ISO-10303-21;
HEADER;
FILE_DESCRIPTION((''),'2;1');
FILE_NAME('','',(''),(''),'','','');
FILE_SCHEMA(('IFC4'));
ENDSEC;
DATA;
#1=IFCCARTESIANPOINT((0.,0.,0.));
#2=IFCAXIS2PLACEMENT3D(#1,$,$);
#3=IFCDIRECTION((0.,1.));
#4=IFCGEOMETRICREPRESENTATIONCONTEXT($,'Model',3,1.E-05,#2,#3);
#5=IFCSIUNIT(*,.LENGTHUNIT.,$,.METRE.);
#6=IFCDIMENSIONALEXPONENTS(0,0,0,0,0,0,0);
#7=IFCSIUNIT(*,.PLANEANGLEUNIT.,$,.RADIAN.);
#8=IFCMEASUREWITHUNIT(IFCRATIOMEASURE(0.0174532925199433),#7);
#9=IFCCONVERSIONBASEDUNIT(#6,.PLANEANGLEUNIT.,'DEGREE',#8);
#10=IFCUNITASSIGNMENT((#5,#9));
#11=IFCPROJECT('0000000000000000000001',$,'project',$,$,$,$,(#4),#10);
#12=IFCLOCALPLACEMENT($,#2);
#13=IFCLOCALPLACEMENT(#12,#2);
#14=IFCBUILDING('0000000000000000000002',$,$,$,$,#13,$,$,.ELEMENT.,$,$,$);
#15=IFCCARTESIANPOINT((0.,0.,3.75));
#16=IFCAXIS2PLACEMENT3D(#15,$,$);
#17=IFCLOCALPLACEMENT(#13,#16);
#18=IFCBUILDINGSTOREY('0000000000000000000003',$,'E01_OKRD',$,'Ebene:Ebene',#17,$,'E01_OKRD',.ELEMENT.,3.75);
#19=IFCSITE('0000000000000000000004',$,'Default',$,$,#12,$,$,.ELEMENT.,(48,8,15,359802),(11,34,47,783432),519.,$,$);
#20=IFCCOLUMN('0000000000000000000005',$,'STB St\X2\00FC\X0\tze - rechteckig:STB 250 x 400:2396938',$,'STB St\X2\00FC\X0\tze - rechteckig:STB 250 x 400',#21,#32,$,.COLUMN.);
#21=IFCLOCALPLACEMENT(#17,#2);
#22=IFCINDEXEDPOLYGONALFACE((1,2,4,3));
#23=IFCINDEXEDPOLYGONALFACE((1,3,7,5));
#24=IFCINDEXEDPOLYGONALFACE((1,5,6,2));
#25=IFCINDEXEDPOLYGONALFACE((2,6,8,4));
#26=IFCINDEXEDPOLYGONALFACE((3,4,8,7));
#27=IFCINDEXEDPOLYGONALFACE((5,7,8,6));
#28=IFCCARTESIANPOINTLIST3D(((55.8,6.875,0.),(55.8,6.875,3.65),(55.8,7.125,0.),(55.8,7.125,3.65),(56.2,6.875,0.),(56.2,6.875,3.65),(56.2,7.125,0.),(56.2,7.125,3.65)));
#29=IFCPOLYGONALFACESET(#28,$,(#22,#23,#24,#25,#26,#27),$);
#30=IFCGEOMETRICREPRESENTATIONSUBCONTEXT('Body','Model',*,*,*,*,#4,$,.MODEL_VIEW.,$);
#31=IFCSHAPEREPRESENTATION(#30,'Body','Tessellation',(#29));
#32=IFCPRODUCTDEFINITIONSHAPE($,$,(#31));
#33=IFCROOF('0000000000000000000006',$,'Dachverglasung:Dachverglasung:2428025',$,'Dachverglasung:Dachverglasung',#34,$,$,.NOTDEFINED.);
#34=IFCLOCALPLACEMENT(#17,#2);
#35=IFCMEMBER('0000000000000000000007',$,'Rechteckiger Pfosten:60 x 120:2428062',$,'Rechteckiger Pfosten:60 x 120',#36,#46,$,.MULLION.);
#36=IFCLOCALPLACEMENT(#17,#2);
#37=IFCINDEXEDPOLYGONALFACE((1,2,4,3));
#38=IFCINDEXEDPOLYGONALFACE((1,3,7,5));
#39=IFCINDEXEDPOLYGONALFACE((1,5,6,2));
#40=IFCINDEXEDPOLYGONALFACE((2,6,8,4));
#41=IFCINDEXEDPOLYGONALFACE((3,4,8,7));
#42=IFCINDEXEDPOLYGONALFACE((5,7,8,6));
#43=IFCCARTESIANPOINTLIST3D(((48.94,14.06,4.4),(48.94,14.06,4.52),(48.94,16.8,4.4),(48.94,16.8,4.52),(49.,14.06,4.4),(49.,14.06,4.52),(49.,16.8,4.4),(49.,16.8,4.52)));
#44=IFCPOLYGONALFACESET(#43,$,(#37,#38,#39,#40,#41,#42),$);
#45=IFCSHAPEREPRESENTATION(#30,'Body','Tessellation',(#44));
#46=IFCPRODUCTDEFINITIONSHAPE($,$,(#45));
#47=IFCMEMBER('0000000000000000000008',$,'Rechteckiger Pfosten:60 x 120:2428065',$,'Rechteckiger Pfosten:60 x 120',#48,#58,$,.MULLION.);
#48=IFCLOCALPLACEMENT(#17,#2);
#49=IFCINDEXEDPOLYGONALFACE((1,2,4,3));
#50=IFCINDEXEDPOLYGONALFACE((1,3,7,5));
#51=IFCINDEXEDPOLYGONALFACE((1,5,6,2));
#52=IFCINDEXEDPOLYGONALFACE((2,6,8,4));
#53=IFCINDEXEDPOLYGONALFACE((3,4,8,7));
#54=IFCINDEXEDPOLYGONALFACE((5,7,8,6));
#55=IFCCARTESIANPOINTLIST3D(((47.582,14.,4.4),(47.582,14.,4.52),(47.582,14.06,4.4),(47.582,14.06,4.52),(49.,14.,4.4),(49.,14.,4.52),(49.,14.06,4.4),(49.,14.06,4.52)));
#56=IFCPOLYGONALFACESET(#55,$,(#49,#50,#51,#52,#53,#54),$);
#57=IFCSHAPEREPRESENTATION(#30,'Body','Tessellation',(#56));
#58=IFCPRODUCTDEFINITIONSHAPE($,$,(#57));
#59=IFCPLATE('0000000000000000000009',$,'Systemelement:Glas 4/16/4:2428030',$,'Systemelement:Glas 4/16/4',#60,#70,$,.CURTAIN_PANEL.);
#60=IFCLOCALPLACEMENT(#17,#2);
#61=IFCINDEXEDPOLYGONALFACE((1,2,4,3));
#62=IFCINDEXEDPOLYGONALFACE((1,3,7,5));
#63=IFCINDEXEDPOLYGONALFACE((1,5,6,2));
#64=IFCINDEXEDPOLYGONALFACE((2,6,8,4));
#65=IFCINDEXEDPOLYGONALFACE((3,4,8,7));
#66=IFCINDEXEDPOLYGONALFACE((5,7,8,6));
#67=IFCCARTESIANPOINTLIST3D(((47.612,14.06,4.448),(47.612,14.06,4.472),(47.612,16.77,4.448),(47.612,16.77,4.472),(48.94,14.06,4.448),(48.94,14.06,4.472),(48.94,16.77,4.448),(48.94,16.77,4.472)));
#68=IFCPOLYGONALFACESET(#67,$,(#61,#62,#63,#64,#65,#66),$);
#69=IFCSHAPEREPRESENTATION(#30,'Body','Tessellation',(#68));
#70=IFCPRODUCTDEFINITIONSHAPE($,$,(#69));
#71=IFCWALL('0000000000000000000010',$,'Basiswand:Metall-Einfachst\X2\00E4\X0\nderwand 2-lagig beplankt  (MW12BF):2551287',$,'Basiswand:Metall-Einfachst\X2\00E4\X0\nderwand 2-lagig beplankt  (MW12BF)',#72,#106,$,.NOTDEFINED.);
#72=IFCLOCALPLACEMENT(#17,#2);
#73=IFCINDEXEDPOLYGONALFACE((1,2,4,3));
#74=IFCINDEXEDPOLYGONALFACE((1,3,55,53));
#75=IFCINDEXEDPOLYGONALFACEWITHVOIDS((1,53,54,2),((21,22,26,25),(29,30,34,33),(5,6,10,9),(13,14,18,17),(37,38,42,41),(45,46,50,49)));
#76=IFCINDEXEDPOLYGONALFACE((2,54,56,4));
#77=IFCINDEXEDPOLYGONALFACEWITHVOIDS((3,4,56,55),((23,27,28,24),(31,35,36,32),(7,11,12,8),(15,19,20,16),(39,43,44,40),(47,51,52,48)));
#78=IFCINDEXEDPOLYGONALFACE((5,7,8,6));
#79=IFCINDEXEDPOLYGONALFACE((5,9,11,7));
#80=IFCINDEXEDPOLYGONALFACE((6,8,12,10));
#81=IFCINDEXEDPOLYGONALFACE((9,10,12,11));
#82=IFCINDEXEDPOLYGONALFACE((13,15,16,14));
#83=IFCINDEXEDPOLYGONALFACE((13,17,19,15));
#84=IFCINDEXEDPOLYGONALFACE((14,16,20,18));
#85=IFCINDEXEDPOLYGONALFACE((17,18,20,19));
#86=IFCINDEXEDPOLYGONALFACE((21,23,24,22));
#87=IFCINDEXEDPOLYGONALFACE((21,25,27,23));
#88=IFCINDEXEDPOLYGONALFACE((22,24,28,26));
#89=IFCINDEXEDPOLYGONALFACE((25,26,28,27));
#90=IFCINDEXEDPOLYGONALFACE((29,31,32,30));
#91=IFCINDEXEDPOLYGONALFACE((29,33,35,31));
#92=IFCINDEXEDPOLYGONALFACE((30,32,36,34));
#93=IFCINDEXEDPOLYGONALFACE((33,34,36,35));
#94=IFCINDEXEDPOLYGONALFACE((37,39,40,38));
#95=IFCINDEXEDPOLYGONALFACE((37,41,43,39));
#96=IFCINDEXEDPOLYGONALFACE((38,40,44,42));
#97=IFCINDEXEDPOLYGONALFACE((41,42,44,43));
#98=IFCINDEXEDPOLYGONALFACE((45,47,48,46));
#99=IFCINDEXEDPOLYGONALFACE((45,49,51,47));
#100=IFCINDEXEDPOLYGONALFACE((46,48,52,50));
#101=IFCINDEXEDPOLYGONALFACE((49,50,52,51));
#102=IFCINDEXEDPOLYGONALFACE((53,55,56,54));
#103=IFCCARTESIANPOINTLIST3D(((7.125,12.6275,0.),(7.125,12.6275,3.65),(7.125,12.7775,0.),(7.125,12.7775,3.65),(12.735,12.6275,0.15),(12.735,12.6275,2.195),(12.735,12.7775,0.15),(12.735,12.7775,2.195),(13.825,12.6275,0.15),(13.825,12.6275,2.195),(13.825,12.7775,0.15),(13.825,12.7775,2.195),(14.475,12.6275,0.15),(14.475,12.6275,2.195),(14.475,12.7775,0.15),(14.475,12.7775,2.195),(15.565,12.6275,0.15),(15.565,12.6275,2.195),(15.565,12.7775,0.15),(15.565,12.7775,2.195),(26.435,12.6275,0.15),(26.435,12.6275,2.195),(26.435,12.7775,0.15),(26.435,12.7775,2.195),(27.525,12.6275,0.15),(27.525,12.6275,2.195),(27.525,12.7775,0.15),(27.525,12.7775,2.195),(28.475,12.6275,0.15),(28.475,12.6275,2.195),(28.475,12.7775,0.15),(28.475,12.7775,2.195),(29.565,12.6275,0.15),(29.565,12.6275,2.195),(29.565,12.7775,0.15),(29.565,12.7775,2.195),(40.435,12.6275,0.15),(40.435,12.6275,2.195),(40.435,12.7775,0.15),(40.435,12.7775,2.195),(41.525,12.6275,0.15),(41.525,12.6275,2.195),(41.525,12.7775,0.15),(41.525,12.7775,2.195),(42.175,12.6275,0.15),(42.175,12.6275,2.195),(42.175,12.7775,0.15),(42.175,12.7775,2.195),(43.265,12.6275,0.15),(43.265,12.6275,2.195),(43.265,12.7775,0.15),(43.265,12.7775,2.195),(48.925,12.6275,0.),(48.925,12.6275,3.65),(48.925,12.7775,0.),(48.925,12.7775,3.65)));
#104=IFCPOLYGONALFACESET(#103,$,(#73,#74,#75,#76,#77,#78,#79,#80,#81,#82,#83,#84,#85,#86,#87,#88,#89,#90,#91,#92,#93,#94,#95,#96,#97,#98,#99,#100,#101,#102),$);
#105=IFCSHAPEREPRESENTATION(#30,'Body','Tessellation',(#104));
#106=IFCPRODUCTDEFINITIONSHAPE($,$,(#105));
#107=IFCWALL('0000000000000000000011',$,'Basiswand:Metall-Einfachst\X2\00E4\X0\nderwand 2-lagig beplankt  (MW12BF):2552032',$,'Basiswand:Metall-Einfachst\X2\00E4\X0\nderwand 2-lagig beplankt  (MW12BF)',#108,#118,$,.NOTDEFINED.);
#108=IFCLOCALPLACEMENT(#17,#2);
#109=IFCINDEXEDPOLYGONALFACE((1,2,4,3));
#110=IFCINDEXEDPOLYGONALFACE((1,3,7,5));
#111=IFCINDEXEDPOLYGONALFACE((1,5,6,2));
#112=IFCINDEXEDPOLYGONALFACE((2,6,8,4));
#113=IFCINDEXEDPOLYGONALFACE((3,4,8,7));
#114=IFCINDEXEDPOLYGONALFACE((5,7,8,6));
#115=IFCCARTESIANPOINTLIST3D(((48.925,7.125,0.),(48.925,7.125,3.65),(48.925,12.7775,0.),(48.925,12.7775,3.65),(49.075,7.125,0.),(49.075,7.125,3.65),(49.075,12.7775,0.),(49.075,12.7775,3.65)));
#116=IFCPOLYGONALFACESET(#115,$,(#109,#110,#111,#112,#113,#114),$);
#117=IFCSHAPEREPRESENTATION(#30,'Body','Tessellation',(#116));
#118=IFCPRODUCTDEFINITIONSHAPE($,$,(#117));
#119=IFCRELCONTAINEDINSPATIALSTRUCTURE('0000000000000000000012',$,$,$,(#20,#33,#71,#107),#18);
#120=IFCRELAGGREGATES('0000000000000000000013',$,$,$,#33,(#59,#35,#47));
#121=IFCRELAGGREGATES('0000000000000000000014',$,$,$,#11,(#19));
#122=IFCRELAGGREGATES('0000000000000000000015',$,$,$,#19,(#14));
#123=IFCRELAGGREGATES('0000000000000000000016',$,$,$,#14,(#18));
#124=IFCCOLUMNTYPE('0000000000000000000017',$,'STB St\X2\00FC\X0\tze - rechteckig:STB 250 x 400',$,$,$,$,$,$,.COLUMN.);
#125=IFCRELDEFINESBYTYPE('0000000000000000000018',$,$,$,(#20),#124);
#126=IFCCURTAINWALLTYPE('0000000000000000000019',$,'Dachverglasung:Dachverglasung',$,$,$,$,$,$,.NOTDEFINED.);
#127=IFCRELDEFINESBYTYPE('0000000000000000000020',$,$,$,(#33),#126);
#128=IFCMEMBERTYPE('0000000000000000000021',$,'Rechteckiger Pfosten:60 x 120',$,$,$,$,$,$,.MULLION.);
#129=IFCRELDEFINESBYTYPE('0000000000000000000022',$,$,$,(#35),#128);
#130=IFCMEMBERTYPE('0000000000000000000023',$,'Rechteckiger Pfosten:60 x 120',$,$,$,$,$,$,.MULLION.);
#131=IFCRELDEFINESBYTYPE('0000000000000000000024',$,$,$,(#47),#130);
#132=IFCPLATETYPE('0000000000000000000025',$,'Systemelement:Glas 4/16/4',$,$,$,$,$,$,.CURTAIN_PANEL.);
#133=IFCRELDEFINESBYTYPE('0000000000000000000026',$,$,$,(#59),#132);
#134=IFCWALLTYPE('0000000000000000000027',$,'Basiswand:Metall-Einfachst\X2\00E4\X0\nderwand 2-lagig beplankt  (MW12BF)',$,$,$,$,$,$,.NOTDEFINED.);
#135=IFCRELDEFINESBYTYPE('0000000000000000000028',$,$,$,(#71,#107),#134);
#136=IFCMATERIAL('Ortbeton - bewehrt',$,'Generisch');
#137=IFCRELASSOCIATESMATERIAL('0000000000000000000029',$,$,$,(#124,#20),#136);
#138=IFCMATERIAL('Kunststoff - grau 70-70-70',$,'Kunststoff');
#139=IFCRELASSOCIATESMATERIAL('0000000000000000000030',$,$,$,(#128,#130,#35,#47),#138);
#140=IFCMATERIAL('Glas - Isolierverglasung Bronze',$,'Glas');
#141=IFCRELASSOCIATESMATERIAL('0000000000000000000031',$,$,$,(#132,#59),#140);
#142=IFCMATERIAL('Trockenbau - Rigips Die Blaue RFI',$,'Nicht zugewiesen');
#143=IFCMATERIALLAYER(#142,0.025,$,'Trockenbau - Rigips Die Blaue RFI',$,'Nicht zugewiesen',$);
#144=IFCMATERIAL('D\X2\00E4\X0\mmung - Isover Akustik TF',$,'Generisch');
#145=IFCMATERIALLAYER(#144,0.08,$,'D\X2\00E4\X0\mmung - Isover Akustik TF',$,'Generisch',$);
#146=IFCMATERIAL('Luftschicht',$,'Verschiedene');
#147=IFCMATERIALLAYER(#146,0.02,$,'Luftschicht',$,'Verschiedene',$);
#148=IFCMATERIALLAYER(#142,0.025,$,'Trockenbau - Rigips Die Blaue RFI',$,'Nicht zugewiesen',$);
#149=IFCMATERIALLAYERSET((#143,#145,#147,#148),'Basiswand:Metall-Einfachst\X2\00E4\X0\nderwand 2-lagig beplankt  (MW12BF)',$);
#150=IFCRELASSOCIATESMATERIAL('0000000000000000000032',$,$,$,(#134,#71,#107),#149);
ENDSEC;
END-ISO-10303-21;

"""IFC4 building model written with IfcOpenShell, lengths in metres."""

from ifc_helpers import new_model, entity, si_unit, converted_unit, direction, frame, frame_2d, origin, origin_2d_with_axis, place, context, subcontext, project, spatial, rectangle, extrude, shape, source, transform, mapped, material, layer, layer_set, layer_usage, material_profile, profile_set, profile_usage, type_object, type_shapes, element, aggregate, save


model = new_model("IFC4")

# Units and contexts
model_context = context("Model", 3, precision=1e-05, world=origin(), true_north=direction((0.0, 1.0)))
body_context = subcontext(model_context, "Body", "Model", "MODEL_VIEW")
footprint_context = subcontext(model_context, "FootPrint", "Model", "MODEL_VIEW")
ifc_project = project(units=[si_unit("LENGTHUNIT", "METRE"), converted_unit("PLANEANGLEUNIT", "DEGREE", entity("IfcRatioMeasure", 0.0174532925199433), si_unit("PLANEANGLEUNIT", "RADIAN"), dimensions=[0, 0, 0, 0, 0, 0, 0])], contexts=[model_context])

# Site, building, storey
site_placement = place(None, frame((0.0, 0.0, 0.0)))
site = spatial("IfcSite", under=ifc_project, at=site_placement, Name="Default", CompositionType="ELEMENT", RefLatitude=(48, 8, 15, 359802), RefLongitude=(11, 34, 47, 783432), RefElevation=519.0)
building_placement = place(site_placement, origin())
building = spatial("IfcBuilding", under=site, at=building_placement, CompositionType="ELEMENT")
storey_placement = place(building_placement, frame((0.0, 0.0, 3.75)))
storey = spatial("IfcBuildingStorey", under=building, at=storey_placement, Name="E01_OKRD", ObjectType="Ebene:Ebene", LongName="E01_OKRD", CompositionType="ELEMENT", Elevation=3.75)

# Column
ifc_material_1 = material(Name="Ortbeton - bewehrt", Category="Generisch")
ifc_material_profile_1 = material_profile(ifc_material_1, rectangle(XDim=0.4, YDim=0.25, at=frame_2d((0.0, 0.0), x_axis=(1.0, 0.0))), Name="STB 250 x 400")
ifc_profile_set_1 = profile_set([ifc_material_profile_1], Name="STB 250 x 400")
ifc_profile_usage_1 = profile_usage(ifc_profile_set_1)
column_type = type_object("IfcColumnType", Name="STB Stütze - rechteckig:STB 250 x 400", PredefinedType="COLUMN", material=ifc_profile_set_1)
shared_shape_1 = source(origin(), body_context, "Body", "SweptSolid", [
    extrude(rectangle(XDim=0.4, YDim=0.25, at=frame_2d((0.0, 0.0), x_axis=(1.0, 0.0))), frame((0.2, 0.125, 0.0), z_axis=(0.0, 0.0, 1.0), x_axis=(-1.0, 0.0, 0.0)), (0.0, 0.0, 1.0), 3.65),
])
type_shapes(column_type, [shared_shape_1])
column_placement = place(storey_placement, frame((55.8, 6.875, 0.0)))
element("IfcColumn", 1, at=column_placement, inside=storey, type_object=column_type, material=ifc_profile_usage_1, Name="STB Stütze - rechteckig:STB 250 x 400:2396938", ObjectType="STB Stütze - rechteckig:STB 250 x 400", PredefinedType="COLUMN", context=body_context, shape_type="MappedRepresentation", body=[
    mapped(shared_shape_1, transform((0.0, 0.0, 0.0), scale=1.0)),
])

# Roof, members, plate
curtain_wall_type = type_object("IfcCurtainWallType", Name="Dachverglasung:Dachverglasung", PredefinedType="NOTDEFINED")
roof_placement = place(storey_placement, frame((0.0, 0.0, -3.75)))
roof = element("IfcRoof", 2, at=roof_placement, inside=storey, type_object=curtain_wall_type, Name="Dachverglasung:Dachverglasung:2428025", ObjectType="Dachverglasung:Dachverglasung", PredefinedType="NOTDEFINED")
ifc_material_2 = material(Name="Kunststoff - grau 70-70-70", Category="Kunststoff")
ifc_material_profile_2 = material_profile(ifc_material_2, rectangle(XDim=0.06, YDim=0.12, at=frame_2d((0.0, 0.0), x_axis=(1.0, 0.0))), Name="60 x 120")
ifc_profile_set_2 = profile_set([ifc_material_profile_2], Name="60 x 120")
ifc_profile_usage_2 = profile_usage(ifc_profile_set_2)
member_type_1 = type_object("IfcMemberType", Name="Rechteckiger Pfosten:60 x 120", PredefinedType="MULLION", material=ifc_profile_set_2)
shared_shape_2 = source(origin(), body_context, "Body", "SweptSolid", [
    extrude(rectangle(XDim=0.06, YDim=0.12, at=origin_2d_with_axis()), frame((-0.03, 0.0, -2.74), z_axis=(0.0, 0.0, 1.0), x_axis=(-1.0, 0.0, 0.0)), (0.0, 0.0, 1.0), 2.74),
])
type_shapes(member_type_1, [shared_shape_2])
member_1_placement = place(storey_placement, frame((49.0, 16.8, 4.46), z_axis=(0.0, 1.0, 0.0), x_axis=(1.0, 0.0, 0.0)))
member_1 = element("IfcMember", 3, at=member_1_placement, type_object=member_type_1, material=ifc_profile_usage_2, Name="Rechteckiger Pfosten:60 x 120:2428062", ObjectType="Rechteckiger Pfosten:60 x 120", PredefinedType="MULLION", context=body_context, shape_type="MappedRepresentation", body=[
    mapped(shared_shape_2, transform((0.0, 0.0, 0.0), scale=1.0)),
])
ifc_profile_usage_3 = profile_usage(ifc_profile_set_2)
member_type_2 = type_object("IfcMemberType", Name="Rechteckiger Pfosten:60 x 120", PredefinedType="MULLION", material=ifc_profile_set_2)
shared_shape_3 = source(origin(), body_context, "Body", "SweptSolid", [
    extrude(rectangle(XDim=0.06, YDim=0.12, at=origin_2d_with_axis()), frame((-0.03, 0.0, -1.418), z_axis=(0.0, 0.0, 1.0), x_axis=(-1.0, 0.0, 0.0)), (0.0, 0.0, 1.0), 1.418),
])
type_shapes(member_type_2, [shared_shape_3])
member_2_placement = place(storey_placement, frame((49.0, 14.0, 4.46), z_axis=(1.0, 0.0, 0.0), x_axis=(0.0, -1.0, 0.0)))
member_2 = element("IfcMember", 4, at=member_2_placement, type_object=member_type_2, material=ifc_profile_usage_3, Name="Rechteckiger Pfosten:60 x 120:2428065", ObjectType="Rechteckiger Pfosten:60 x 120", PredefinedType="MULLION", context=body_context, shape_type="MappedRepresentation", body=[
    mapped(shared_shape_3, transform((0.0, 0.0, 0.0), scale=1.0)),
])
ifc_material_3 = material(Name="Glas - Isolierverglasung Bronze", Category="Glas")
plate_type = type_object("IfcPlateType", Name="Systemelement:Glas 4/16/4", PredefinedType="CURTAIN_PANEL", material=ifc_material_3)
shared_shape_4 = source(origin(), body_context, "Body", "SweptSolid", [
    extrude(rectangle(XDim=0.024, YDim=2.71, at=origin_2d_with_axis()), frame((0.0, 0.0, 0.0), z_axis=(0.0, 0.0, 1.0), x_axis=(0.0, 1.0, 0.0)), (0.0, 0.0, 1.0), 1.328),
])
cartesian_point = entity("IfcCartesianPoint", [1.355, -0.012])
shared_shape_5 = source(origin(), footprint_context, "FootPrint", "Curve2D", [
    entity("IfcPolyline", [cartesian_point, entity("IfcCartesianPoint", [1.355, 0.012]), entity("IfcCartesianPoint", [-1.355, 0.012]), entity("IfcCartesianPoint", [-1.355, -0.012]), cartesian_point]),
])
type_shapes(plate_type, [shared_shape_4, shared_shape_5])
plate_placement = place(roof_placement, frame((48.94, 15.415, 8.21), z_axis=(-1.0, 0.0, 0.0), x_axis=(0.0, 1.0, 0.0)))
plate = element("IfcPlate", 5, at=plate_placement, type_object=plate_type, material=ifc_material_3, Name="Systemelement:Glas 4/16/4:2428030", ObjectType="Systemelement:Glas 4/16/4", PredefinedType="CURTAIN_PANEL", shapes=[
    shape(body_context, "Body", "MappedRepresentation", [mapped(shared_shape_4, transform((0.0, 0.0, 0.0), scale=1.0))]),
    shape(body_context, "Body", "MappedRepresentation", [mapped(shared_shape_5, transform((0.0, 0.0, 0.0), scale=1.0))]),
])
aggregate(roof, [plate, member_1, member_2])

# Wall, openings
ifc_material_4 = material(Name="Trockenbau - Rigips Die Blaue RFI", Category="Nicht zugewiesen")
ifc_layer_1 = layer(ifc_material_4, 0.025, Name="Trockenbau - Rigips Die Blaue RFI", Category="Nicht zugewiesen")
ifc_material_5 = material(Name="Dämmung - Isover Akustik TF", Category="Generisch")
ifc_layer_2 = layer(ifc_material_5, 0.08, Name="Dämmung - Isover Akustik TF", Category="Generisch")
ifc_material_6 = material(Name="Luftschicht", Category="Verschiedene")
ifc_layer_3 = layer(ifc_material_6, 0.02, Name="Luftschicht", Category="Verschiedene")
ifc_layer_4 = layer(ifc_material_4, 0.025, Name="Trockenbau - Rigips Die Blaue RFI", Category="Nicht zugewiesen")
ifc_layer_set_1 = layer_set([ifc_layer_1, ifc_layer_2, ifc_layer_3, ifc_layer_4], Name="Basiswand:Metall-Einfachständerwand 2-lagig beplankt  (MW12BF)")
ifc_layer_usage_1 = layer_usage(ifc_layer_set_1, "AXIS2", "NEGATIVE", 0.075)
wall_type_1 = type_object("IfcWallType", Name="Basiswand:Metall-Einfachständerwand 2-lagig beplankt  (MW12BF)", PredefinedType="NOTDEFINED", material=ifc_layer_set_1)
wall_1_placement = place(storey_placement, frame((48.925, 12.7025, 0.0), z_axis=(0.0, 0.0, 1.0), x_axis=(-1.0, 0.0, 0.0)))
wall_1 = element("IfcWall", 6, at=wall_1_placement, inside=storey, type_object=wall_type_1, material=ifc_layer_usage_1, Name="Basiswand:Metall-Einfachständerwand 2-lagig beplankt  (MW12BF):2551287", ObjectType="Basiswand:Metall-Einfachständerwand 2-lagig beplankt  (MW12BF)", PredefinedType="NOTDEFINED", context=body_context, shape_type="SweptSolid", body=[
    extrude(rectangle(XDim=41.8, YDim=0.15, at=frame_2d((20.9, 0.0), x_axis=(-1.0, 0.0))), origin(), (0.0, 0.0, 1.0), 3.65),
])
opening_1_placement = place(wall_1_placement, frame((19.36, -0.075, 0.15)))
element("IfcOpeningElement", 7, at=opening_1_placement, cuts=wall_1, ObjectType="Opening", PredefinedType="OPENING", context=body_context, shape_type="SweptSolid", body=[
    extrude(rectangle(XDim=2.045, YDim=1.09, at=frame_2d((1.0225, 0.545), x_axis=(-1.0, 0.0))), frame((0.0, 0.0, 0.0), z_axis=(0.0, 1.0, 0.0), x_axis=(0.0, 0.0, 1.0)), (0.0, 0.0, 1.0), 0.15),
])
opening_2_placement = place(wall_1_placement, frame((21.4, -0.075, 0.15)))
element("IfcOpeningElement", 8, at=opening_2_placement, cuts=wall_1, ObjectType="Opening", PredefinedType="OPENING", context=body_context, shape_type="SweptSolid", body=[
    extrude(rectangle(XDim=2.045, YDim=1.09, at=frame_2d((1.0225, 0.545), x_axis=(-1.0, 0.0))), frame((0.0, 0.0, 0.0), z_axis=(0.0, 1.0, 0.0), x_axis=(0.0, 0.0, 1.0)), (0.0, 0.0, 1.0), 0.15),
])
opening_3_placement = place(wall_1_placement, frame((35.1, -0.075, 0.15)))
element("IfcOpeningElement", 9, at=opening_3_placement, cuts=wall_1, ObjectType="Opening", PredefinedType="OPENING", context=body_context, shape_type="SweptSolid", body=[
    extrude(rectangle(XDim=2.045, YDim=1.09, at=frame_2d((1.0225, 0.545), x_axis=(-1.0, 0.0))), frame((0.0, 0.0, 0.0), z_axis=(0.0, 1.0, 0.0), x_axis=(0.0, 0.0, 1.0)), (0.0, 0.0, 1.0), 0.15),
])
opening_4_placement = place(wall_1_placement, frame((33.36, -0.075, 0.15)))
element("IfcOpeningElement", 10, at=opening_4_placement, cuts=wall_1, ObjectType="Opening", PredefinedType="OPENING", context=body_context, shape_type="SweptSolid", body=[
    extrude(rectangle(XDim=2.045, YDim=1.09, at=frame_2d((1.0225, 0.545), x_axis=(-1.0, 0.0))), frame((0.0, 0.0, 0.0), z_axis=(0.0, 1.0, 0.0), x_axis=(0.0, 0.0, 1.0)), (0.0, 0.0, 1.0), 0.15),
])
opening_5_placement = place(wall_1_placement, frame((7.4, -0.075, 0.15)))
element("IfcOpeningElement", 11, at=opening_5_placement, cuts=wall_1, ObjectType="Opening", PredefinedType="OPENING", context=body_context, shape_type="SweptSolid", body=[
    extrude(rectangle(XDim=2.045, YDim=1.09, at=frame_2d((1.0225, 0.545), x_axis=(-1.0, 0.0))), frame((0.0, 0.0, 0.0), z_axis=(0.0, 1.0, 0.0), x_axis=(0.0, 0.0, 1.0)), (0.0, 0.0, 1.0), 0.15),
])
opening_6_placement = place(wall_1_placement, frame((5.66, -0.075, 0.15)))
element("IfcOpeningElement", 12, at=opening_6_placement, cuts=wall_1, ObjectType="Opening", PredefinedType="OPENING", context=body_context, shape_type="SweptSolid", body=[
    extrude(rectangle(XDim=2.045, YDim=1.09, at=frame_2d((1.0225, 0.545), x_axis=(-1.0, 0.0))), frame((0.0, 0.0, 0.0), z_axis=(0.0, 1.0, 0.0), x_axis=(0.0, 0.0, 1.0)), (0.0, 0.0, 1.0), 0.15),
])

# Wall
ifc_layer_usage_2 = layer_usage(ifc_layer_set_1, "AXIS2", "NEGATIVE", 0.075)
wall_2_placement = place(storey_placement, frame((49.0, 7.125, 0.0), z_axis=(0.0, 0.0, 1.0), x_axis=(0.0, 1.0, 0.0)))
element("IfcWall", 13, at=wall_2_placement, inside=storey, type_object=wall_type_1, material=ifc_layer_usage_2, Name="Basiswand:Metall-Einfachständerwand 2-lagig beplankt  (MW12BF):2552032", ObjectType="Basiswand:Metall-Einfachständerwand 2-lagig beplankt  (MW12BF)", PredefinedType="NOTDEFINED", context=body_context, shape_type="SweptSolid", body=[
    extrude(rectangle(XDim=5.6525, YDim=0.15, at=frame_2d((2.8263, 0.0), x_axis=(-1.0, 0.0))), origin(), (0.0, 0.0, 1.0), 3.65),
])

save(model, "model.ifc")
